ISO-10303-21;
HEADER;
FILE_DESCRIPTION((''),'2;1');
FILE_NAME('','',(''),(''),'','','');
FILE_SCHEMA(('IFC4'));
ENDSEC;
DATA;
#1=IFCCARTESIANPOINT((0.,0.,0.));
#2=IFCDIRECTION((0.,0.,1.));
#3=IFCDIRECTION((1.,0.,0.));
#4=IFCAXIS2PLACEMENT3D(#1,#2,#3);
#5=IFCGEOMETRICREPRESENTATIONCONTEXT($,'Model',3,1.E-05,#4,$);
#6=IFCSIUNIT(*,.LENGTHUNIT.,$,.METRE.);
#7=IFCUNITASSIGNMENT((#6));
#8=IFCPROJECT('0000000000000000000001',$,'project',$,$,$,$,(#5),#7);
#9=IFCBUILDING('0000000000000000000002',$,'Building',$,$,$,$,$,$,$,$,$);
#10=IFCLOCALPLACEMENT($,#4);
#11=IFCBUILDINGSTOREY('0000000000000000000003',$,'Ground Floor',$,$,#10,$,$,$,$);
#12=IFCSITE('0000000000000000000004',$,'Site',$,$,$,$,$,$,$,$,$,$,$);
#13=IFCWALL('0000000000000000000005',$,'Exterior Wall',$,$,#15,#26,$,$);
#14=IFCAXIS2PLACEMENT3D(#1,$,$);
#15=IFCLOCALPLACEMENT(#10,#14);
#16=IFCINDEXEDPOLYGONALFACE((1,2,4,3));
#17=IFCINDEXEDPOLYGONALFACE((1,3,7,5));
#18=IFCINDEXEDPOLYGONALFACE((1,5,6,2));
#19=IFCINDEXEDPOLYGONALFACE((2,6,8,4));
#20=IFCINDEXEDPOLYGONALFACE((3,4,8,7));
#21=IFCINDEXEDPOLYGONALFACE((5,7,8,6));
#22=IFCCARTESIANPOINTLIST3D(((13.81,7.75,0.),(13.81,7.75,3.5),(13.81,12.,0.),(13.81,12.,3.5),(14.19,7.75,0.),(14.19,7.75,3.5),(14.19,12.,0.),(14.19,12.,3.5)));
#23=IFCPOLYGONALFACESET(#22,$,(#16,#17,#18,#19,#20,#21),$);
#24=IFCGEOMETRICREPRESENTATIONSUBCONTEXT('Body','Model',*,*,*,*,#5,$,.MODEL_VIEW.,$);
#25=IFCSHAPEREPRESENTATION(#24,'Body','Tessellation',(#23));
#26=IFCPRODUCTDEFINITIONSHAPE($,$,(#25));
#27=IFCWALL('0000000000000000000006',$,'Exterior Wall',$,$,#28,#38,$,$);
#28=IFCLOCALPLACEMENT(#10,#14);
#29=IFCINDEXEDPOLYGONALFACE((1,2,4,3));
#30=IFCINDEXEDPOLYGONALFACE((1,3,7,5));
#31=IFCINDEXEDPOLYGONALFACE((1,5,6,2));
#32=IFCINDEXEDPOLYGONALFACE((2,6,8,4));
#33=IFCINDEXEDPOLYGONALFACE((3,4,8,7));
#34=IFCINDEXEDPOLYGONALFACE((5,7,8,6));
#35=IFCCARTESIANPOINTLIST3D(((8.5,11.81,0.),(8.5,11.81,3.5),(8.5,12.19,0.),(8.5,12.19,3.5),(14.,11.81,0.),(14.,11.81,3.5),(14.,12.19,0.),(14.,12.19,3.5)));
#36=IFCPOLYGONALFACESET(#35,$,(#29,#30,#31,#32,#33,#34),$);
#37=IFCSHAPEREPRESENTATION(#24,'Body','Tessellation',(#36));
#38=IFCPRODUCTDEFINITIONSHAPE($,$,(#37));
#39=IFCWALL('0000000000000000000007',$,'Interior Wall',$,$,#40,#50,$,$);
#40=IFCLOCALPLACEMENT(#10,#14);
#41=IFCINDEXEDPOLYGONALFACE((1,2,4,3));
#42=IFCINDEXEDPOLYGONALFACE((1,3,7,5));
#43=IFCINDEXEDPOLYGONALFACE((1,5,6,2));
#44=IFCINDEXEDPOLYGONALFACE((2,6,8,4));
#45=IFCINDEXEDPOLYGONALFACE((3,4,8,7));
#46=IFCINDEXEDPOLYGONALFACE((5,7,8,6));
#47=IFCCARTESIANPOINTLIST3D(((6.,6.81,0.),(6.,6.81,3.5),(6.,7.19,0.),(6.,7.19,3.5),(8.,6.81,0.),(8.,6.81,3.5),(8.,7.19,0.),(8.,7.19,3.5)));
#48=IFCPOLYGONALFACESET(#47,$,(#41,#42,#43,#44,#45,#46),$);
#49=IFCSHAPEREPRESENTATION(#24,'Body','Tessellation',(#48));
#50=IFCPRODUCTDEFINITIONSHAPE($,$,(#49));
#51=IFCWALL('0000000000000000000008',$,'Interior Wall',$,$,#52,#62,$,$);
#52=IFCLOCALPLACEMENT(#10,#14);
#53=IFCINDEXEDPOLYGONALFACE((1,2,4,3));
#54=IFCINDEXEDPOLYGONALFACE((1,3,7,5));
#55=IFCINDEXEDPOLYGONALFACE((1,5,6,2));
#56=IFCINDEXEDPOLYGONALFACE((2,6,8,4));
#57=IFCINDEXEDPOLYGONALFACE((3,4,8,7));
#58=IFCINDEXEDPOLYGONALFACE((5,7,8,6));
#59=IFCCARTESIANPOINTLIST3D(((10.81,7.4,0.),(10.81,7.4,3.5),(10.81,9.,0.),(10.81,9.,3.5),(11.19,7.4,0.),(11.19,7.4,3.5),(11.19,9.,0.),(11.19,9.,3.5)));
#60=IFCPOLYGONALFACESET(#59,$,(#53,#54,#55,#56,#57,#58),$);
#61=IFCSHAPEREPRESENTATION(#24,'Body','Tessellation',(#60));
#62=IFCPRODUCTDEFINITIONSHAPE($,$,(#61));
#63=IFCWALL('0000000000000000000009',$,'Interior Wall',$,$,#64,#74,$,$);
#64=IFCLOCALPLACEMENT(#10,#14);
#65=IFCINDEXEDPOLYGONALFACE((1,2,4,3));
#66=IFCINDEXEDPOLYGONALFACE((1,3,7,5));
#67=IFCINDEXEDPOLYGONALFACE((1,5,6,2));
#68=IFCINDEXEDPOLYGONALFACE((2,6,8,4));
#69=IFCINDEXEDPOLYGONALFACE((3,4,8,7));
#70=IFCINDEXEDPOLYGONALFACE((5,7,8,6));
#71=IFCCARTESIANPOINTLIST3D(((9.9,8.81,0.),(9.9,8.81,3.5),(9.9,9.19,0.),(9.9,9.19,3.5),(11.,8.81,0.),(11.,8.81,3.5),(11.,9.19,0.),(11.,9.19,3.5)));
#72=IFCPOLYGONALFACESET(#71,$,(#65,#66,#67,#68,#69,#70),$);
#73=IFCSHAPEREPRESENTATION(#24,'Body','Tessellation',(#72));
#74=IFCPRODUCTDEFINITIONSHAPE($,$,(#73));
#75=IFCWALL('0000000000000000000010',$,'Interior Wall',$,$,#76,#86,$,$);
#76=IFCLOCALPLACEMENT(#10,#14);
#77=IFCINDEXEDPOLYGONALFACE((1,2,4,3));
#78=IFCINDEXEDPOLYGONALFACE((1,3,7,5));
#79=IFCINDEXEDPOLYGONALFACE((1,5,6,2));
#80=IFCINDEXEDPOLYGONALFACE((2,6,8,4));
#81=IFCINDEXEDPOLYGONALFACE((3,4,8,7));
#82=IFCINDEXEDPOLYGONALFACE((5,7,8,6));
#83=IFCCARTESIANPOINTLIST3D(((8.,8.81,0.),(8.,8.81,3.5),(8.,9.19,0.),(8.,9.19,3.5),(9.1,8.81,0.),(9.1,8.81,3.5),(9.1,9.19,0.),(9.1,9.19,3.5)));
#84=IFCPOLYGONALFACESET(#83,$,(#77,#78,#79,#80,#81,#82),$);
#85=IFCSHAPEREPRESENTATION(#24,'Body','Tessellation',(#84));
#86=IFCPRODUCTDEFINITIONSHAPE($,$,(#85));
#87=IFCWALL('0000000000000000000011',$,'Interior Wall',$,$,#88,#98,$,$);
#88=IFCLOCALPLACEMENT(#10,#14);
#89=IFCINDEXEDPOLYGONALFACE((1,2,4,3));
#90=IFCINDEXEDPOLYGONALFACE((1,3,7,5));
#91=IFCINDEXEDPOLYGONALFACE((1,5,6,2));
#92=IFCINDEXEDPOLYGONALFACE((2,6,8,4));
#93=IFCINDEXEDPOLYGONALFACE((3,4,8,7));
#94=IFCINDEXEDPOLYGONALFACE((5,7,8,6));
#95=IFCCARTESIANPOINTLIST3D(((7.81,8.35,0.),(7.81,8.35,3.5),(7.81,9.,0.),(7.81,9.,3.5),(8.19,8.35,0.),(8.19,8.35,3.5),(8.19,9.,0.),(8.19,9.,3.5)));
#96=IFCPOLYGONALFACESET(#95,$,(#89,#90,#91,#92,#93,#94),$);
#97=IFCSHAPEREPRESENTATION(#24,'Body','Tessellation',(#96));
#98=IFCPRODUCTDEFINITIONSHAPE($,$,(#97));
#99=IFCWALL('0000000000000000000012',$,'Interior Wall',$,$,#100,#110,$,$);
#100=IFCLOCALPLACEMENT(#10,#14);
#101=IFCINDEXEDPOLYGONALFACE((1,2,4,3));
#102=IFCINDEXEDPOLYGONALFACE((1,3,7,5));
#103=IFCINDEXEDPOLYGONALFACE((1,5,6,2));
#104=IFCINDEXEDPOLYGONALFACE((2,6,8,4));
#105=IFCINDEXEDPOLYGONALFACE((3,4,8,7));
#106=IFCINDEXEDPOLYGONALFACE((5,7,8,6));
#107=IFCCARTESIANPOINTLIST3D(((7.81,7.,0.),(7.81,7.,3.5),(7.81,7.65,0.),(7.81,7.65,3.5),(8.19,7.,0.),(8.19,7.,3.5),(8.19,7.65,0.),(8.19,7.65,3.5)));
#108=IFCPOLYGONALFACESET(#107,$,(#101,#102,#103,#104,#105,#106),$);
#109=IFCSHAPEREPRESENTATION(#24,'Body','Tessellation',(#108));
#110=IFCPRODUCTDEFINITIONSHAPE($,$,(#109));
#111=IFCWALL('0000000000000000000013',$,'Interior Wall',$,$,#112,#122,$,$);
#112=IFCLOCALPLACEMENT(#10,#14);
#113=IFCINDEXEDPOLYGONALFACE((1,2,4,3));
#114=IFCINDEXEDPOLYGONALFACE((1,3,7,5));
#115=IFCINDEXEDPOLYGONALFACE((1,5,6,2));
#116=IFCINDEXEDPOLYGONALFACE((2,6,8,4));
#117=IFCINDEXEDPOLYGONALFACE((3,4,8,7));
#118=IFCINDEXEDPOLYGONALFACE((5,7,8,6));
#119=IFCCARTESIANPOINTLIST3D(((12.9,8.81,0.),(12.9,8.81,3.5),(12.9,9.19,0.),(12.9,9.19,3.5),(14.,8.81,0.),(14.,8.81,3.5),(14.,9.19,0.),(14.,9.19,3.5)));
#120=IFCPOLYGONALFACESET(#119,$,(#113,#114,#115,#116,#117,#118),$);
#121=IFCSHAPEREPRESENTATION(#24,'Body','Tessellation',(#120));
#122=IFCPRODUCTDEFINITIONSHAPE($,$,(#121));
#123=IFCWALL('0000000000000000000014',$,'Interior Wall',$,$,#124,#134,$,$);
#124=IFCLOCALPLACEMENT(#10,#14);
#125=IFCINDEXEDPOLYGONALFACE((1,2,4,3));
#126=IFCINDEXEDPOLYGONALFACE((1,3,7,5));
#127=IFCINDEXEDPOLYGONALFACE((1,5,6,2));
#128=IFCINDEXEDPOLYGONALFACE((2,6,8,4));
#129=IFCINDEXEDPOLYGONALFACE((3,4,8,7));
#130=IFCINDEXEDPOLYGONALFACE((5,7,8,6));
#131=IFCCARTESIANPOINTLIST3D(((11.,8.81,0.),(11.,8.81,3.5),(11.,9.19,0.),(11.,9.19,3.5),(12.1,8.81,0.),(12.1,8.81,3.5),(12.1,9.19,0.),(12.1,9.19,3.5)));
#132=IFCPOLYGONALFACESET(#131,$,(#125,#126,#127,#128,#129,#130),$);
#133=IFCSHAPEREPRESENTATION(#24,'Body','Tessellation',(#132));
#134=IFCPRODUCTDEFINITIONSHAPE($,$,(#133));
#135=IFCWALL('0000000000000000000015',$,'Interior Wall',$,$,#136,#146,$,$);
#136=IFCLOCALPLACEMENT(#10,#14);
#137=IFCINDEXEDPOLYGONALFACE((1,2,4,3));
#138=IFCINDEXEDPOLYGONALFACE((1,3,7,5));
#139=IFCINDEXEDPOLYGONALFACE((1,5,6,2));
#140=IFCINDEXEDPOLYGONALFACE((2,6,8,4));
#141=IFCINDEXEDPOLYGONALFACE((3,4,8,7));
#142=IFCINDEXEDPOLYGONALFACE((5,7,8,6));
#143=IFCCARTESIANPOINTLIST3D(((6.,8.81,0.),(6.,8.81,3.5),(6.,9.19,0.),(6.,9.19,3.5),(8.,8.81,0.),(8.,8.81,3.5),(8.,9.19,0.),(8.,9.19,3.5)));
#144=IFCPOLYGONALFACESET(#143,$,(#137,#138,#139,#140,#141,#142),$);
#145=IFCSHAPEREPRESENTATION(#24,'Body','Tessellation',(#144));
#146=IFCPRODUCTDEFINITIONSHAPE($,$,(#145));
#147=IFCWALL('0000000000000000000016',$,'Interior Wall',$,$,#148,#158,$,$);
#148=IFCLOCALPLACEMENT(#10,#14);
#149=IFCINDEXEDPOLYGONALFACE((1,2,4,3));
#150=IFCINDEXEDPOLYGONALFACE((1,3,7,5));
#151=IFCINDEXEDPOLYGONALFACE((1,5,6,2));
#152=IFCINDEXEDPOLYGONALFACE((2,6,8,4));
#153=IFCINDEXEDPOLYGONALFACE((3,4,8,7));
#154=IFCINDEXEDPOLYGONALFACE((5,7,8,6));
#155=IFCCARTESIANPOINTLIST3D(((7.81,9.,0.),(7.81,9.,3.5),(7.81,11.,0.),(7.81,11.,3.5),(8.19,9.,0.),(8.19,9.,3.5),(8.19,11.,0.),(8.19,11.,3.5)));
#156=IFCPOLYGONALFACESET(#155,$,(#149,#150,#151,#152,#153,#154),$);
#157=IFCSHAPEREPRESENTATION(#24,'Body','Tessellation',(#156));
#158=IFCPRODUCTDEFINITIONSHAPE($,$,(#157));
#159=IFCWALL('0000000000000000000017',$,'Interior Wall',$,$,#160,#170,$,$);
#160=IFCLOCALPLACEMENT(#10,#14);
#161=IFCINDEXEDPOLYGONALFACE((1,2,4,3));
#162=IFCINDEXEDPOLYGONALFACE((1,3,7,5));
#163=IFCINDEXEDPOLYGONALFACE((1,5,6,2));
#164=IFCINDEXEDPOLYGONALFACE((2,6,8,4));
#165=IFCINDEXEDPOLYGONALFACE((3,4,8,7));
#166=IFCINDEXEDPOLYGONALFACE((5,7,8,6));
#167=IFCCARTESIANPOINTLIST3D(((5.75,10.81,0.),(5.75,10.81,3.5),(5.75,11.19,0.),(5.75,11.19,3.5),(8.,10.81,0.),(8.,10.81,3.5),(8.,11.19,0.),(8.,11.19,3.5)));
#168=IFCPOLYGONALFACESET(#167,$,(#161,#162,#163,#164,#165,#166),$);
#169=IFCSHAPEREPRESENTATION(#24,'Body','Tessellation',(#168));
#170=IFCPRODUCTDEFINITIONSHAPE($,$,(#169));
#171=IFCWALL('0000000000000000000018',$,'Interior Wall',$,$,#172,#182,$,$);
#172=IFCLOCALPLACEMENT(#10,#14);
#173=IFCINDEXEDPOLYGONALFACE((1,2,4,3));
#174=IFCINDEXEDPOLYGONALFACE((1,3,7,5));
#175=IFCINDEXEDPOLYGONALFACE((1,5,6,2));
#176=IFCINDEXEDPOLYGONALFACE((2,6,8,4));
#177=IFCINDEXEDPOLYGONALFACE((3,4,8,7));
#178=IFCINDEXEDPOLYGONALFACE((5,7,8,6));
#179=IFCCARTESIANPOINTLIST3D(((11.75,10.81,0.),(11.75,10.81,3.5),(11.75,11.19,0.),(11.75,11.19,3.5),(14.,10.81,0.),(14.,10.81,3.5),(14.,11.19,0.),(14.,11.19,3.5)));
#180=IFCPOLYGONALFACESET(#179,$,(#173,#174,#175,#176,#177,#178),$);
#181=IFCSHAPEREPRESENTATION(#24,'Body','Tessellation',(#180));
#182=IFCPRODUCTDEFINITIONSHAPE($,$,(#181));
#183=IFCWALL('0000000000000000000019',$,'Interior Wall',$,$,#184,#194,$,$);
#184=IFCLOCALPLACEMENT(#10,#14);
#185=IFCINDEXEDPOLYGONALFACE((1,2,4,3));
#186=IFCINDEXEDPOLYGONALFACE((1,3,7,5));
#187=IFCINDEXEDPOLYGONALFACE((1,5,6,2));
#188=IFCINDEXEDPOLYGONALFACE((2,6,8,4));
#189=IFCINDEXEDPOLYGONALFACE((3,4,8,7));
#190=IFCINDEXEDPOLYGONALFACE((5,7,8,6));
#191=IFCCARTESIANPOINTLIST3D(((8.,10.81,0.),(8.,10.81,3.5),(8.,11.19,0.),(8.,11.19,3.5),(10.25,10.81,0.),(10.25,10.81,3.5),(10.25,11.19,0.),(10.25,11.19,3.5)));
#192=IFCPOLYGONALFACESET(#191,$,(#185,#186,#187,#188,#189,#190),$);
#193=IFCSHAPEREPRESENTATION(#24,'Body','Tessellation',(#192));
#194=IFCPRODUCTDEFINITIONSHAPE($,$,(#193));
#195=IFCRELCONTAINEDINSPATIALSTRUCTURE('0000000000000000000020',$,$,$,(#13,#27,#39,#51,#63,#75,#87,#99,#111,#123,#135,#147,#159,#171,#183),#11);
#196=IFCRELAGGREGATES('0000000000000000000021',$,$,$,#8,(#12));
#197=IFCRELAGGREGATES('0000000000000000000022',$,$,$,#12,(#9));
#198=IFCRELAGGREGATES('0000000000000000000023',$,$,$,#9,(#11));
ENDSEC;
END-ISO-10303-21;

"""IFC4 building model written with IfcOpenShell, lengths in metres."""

from ifc_helpers import new_model, si_unit, frame, origin_with_axes, place, context, subcontext, project, spatial, indexed_curve, outline, extrude, element, save


model = new_model("IFC4")

# Units and contexts
model_context = context("Model", 3, precision=1e-05, world=origin_with_axes())
body_context = subcontext(model_context, "Body", "Model", "MODEL_VIEW")
ifc_project = project(units=[si_unit("LENGTHUNIT", "METRE")], contexts=[model_context])

# Site, building, storey
site = spatial("IfcSite", under=ifc_project, Name="Site")
building = spatial("IfcBuilding", under=site, Name="Building")
storey_placement = place(None, origin_with_axes())
storey = spatial("IfcBuildingStorey", under=building, at=storey_placement, Name="Ground Floor")

# Walls
wall_1_placement = place(storey_placement, frame((14.0, 7.75, 0.0), z_axis=(0.0, 0.0, 1.0), x_axis=(0.0, 1.0, 0.0)))
element("IfcWall", 1, at=wall_1_placement, inside=storey, Name="Exterior Wall", context=body_context, shape_type="SweptSolid", body=[
    extrude(outline(indexed_curve([(0.0, 0.0), (0.0, 0.38), (4.25, 0.38), (4.25, 0.0), (0.0, 0.0)], self_intersect=False)), frame((0.0, -0.19, 0.0), z_axis=(0.0, 0.0, 1.0), x_axis=(1.0, 0.0, 0.0)), (0.0, 0.0, 1.0), 3.5),
])
wall_2_placement = place(storey_placement, frame((14.0, 12.0, 0.0), z_axis=(0.0, 0.0, 1.0), x_axis=(-1.0, 0.0, 0.0)))
element("IfcWall", 2, at=wall_2_placement, inside=storey, Name="Exterior Wall", context=body_context, shape_type="SweptSolid", body=[
    extrude(outline(indexed_curve([(0.0, 0.0), (0.0, 0.38), (5.5, 0.38), (5.5, 0.0), (0.0, 0.0)], self_intersect=False)), frame((0.0, -0.19, 0.0), z_axis=(0.0, 0.0, 1.0), x_axis=(1.0, 0.0, 0.0)), (0.0, 0.0, 1.0), 3.5),
])
wall_3_placement = place(storey_placement, frame((8.0, 7.0, 0.0), z_axis=(0.0, 0.0, 1.0), x_axis=(-1.0, 0.0, 0.0)))
element("IfcWall", 3, at=wall_3_placement, inside=storey, Name="Interior Wall", context=body_context, shape_type="SweptSolid", body=[
    extrude(outline(indexed_curve([(0.0, 0.0), (0.0, 0.38), (2.0, 0.38), (2.0, 0.0), (0.0, 0.0)], self_intersect=False)), frame((0.0, -0.19, 0.0), z_axis=(0.0, 0.0, 1.0), x_axis=(1.0, 0.0, 0.0)), (0.0, 0.0, 1.0), 3.5),
])
wall_4_placement = place(storey_placement, frame((11.0, 7.4, 0.0), z_axis=(0.0, 0.0, 1.0), x_axis=(0.0, 1.0, 0.0)))
element("IfcWall", 4, at=wall_4_placement, inside=storey, Name="Interior Wall", context=body_context, shape_type="SweptSolid", body=[
    extrude(outline(indexed_curve([(0.0, 0.0), (0.0, 0.38), (1.6, 0.38), (1.6, 0.0), (0.0, 0.0)], self_intersect=False)), frame((0.0, -0.19, 0.0), z_axis=(0.0, 0.0, 1.0), x_axis=(1.0, 0.0, 0.0)), (0.0, 0.0, 1.0), 3.5),
])
for number, where, z_axis, x_axis, name in (
    (5, (11.0, 9.0, 0.0), (0.0, 0.0, 1.0), (-1.0, 0.0, 0.0), "Interior Wall"),
    (6, (9.1, 9.0, 0.0), (0.0, 0.0, 1.0), (-1.0, 0.0, 0.0), "Interior Wall"),
):
    element("IfcWall", number, at=place(storey_placement, frame(where, z_axis=z_axis, x_axis=x_axis)), inside=storey, Name=name, context=body_context, shape_type="SweptSolid", body=[
        extrude(outline(indexed_curve([(0.0, 0.0), (0.0, 0.38), (1.1, 0.38), (1.1, 0.0), (0.0, 0.0)], self_intersect=False)), frame((0.0, -0.19, 0.0), z_axis=(0.0, 0.0, 1.0), x_axis=(1.0, 0.0, 0.0)), (0.0, 0.0, 1.0), 3.5),
    ])
for number, where, z_axis, x_axis, name in (
    (7, (8.0, 9.0, 0.0), (0.0, 0.0, 1.0), (0.0, -1.0, 0.0), "Interior Wall"),
    (8, (8.0, 7.65, 0.0), (0.0, 0.0, 1.0), (0.0, -1.0, 0.0), "Interior Wall"),
):
    element("IfcWall", number, at=place(storey_placement, frame(where, z_axis=z_axis, x_axis=x_axis)), inside=storey, Name=name, context=body_context, shape_type="SweptSolid", body=[
        extrude(outline(indexed_curve([(0.0, 0.0), (0.0, 0.38), (0.65, 0.38), (0.65, 0.0), (0.0, 0.0)], self_intersect=False)), frame((0.0, -0.19, 0.0), z_axis=(0.0, 0.0, 1.0), x_axis=(1.0, 0.0, 0.0)), (0.0, 0.0, 1.0), 3.5),
    ])
for number, where, z_axis, x_axis, name in (
    (9, (14.0, 9.0, 0.0), (0.0, 0.0, 1.0), (-1.0, 0.0, 0.0), "Interior Wall"),
    (10, (12.1, 9.0, 0.0), (0.0, 0.0, 1.0), (-1.0, 0.0, 0.0), "Interior Wall"),
):
    element("IfcWall", number, at=place(storey_placement, frame(where, z_axis=z_axis, x_axis=x_axis)), inside=storey, Name=name, context=body_context, shape_type="SweptSolid", body=[
        extrude(outline(indexed_curve([(0.0, 0.0), (0.0, 0.38), (1.1, 0.38), (1.1, 0.0), (0.0, 0.0)], self_intersect=False)), frame((0.0, -0.19, 0.0), z_axis=(0.0, 0.0, 1.0), x_axis=(1.0, 0.0, 0.0)), (0.0, 0.0, 1.0), 3.5),
    ])
for number, where, z_axis, x_axis, name in (
    (11, (8.0, 9.0, 0.0), (0.0, 0.0, 1.0), (-1.0, 0.0, 0.0), "Interior Wall"),
    (12, (8.0, 9.0, 0.0), (0.0, 0.0, 1.0), (0.0, 1.0, 0.0), "Interior Wall"),
):
    element("IfcWall", number, at=place(storey_placement, frame(where, z_axis=z_axis, x_axis=x_axis)), inside=storey, Name=name, context=body_context, shape_type="SweptSolid", body=[
        extrude(outline(indexed_curve([(0.0, 0.0), (0.0, 0.38), (2.0, 0.38), (2.0, 0.0), (0.0, 0.0)], self_intersect=False)), frame((0.0, -0.19, 0.0), z_axis=(0.0, 0.0, 1.0), x_axis=(1.0, 0.0, 0.0)), (0.0, 0.0, 1.0), 3.5),
    ])
for number, where, z_axis, x_axis, name in (
    (13, (8.0, 11.0, 0.0), (0.0, 0.0, 1.0), (-1.0, 0.0, 0.0), "Interior Wall"),
    (14, (14.0, 11.0, 0.0), (0.0, 0.0, 1.0), (-1.0, 0.0, 0.0), "Interior Wall"),
    (15, (10.25, 11.0, 0.0), (0.0, 0.0, 1.0), (-1.0, 0.0, 0.0), "Interior Wall"),
):
    element("IfcWall", number, at=place(storey_placement, frame(where, z_axis=z_axis, x_axis=x_axis)), inside=storey, Name=name, context=body_context, shape_type="SweptSolid", body=[
        extrude(outline(indexed_curve([(0.0, 0.0), (0.0, 0.38), (2.25, 0.38), (2.25, 0.0), (0.0, 0.0)], self_intersect=False)), frame((0.0, -0.19, 0.0), z_axis=(0.0, 0.0, 1.0), x_axis=(1.0, 0.0, 0.0)), (0.0, 0.0, 1.0), 3.5),
    ])

save(model, "model.ifc")
